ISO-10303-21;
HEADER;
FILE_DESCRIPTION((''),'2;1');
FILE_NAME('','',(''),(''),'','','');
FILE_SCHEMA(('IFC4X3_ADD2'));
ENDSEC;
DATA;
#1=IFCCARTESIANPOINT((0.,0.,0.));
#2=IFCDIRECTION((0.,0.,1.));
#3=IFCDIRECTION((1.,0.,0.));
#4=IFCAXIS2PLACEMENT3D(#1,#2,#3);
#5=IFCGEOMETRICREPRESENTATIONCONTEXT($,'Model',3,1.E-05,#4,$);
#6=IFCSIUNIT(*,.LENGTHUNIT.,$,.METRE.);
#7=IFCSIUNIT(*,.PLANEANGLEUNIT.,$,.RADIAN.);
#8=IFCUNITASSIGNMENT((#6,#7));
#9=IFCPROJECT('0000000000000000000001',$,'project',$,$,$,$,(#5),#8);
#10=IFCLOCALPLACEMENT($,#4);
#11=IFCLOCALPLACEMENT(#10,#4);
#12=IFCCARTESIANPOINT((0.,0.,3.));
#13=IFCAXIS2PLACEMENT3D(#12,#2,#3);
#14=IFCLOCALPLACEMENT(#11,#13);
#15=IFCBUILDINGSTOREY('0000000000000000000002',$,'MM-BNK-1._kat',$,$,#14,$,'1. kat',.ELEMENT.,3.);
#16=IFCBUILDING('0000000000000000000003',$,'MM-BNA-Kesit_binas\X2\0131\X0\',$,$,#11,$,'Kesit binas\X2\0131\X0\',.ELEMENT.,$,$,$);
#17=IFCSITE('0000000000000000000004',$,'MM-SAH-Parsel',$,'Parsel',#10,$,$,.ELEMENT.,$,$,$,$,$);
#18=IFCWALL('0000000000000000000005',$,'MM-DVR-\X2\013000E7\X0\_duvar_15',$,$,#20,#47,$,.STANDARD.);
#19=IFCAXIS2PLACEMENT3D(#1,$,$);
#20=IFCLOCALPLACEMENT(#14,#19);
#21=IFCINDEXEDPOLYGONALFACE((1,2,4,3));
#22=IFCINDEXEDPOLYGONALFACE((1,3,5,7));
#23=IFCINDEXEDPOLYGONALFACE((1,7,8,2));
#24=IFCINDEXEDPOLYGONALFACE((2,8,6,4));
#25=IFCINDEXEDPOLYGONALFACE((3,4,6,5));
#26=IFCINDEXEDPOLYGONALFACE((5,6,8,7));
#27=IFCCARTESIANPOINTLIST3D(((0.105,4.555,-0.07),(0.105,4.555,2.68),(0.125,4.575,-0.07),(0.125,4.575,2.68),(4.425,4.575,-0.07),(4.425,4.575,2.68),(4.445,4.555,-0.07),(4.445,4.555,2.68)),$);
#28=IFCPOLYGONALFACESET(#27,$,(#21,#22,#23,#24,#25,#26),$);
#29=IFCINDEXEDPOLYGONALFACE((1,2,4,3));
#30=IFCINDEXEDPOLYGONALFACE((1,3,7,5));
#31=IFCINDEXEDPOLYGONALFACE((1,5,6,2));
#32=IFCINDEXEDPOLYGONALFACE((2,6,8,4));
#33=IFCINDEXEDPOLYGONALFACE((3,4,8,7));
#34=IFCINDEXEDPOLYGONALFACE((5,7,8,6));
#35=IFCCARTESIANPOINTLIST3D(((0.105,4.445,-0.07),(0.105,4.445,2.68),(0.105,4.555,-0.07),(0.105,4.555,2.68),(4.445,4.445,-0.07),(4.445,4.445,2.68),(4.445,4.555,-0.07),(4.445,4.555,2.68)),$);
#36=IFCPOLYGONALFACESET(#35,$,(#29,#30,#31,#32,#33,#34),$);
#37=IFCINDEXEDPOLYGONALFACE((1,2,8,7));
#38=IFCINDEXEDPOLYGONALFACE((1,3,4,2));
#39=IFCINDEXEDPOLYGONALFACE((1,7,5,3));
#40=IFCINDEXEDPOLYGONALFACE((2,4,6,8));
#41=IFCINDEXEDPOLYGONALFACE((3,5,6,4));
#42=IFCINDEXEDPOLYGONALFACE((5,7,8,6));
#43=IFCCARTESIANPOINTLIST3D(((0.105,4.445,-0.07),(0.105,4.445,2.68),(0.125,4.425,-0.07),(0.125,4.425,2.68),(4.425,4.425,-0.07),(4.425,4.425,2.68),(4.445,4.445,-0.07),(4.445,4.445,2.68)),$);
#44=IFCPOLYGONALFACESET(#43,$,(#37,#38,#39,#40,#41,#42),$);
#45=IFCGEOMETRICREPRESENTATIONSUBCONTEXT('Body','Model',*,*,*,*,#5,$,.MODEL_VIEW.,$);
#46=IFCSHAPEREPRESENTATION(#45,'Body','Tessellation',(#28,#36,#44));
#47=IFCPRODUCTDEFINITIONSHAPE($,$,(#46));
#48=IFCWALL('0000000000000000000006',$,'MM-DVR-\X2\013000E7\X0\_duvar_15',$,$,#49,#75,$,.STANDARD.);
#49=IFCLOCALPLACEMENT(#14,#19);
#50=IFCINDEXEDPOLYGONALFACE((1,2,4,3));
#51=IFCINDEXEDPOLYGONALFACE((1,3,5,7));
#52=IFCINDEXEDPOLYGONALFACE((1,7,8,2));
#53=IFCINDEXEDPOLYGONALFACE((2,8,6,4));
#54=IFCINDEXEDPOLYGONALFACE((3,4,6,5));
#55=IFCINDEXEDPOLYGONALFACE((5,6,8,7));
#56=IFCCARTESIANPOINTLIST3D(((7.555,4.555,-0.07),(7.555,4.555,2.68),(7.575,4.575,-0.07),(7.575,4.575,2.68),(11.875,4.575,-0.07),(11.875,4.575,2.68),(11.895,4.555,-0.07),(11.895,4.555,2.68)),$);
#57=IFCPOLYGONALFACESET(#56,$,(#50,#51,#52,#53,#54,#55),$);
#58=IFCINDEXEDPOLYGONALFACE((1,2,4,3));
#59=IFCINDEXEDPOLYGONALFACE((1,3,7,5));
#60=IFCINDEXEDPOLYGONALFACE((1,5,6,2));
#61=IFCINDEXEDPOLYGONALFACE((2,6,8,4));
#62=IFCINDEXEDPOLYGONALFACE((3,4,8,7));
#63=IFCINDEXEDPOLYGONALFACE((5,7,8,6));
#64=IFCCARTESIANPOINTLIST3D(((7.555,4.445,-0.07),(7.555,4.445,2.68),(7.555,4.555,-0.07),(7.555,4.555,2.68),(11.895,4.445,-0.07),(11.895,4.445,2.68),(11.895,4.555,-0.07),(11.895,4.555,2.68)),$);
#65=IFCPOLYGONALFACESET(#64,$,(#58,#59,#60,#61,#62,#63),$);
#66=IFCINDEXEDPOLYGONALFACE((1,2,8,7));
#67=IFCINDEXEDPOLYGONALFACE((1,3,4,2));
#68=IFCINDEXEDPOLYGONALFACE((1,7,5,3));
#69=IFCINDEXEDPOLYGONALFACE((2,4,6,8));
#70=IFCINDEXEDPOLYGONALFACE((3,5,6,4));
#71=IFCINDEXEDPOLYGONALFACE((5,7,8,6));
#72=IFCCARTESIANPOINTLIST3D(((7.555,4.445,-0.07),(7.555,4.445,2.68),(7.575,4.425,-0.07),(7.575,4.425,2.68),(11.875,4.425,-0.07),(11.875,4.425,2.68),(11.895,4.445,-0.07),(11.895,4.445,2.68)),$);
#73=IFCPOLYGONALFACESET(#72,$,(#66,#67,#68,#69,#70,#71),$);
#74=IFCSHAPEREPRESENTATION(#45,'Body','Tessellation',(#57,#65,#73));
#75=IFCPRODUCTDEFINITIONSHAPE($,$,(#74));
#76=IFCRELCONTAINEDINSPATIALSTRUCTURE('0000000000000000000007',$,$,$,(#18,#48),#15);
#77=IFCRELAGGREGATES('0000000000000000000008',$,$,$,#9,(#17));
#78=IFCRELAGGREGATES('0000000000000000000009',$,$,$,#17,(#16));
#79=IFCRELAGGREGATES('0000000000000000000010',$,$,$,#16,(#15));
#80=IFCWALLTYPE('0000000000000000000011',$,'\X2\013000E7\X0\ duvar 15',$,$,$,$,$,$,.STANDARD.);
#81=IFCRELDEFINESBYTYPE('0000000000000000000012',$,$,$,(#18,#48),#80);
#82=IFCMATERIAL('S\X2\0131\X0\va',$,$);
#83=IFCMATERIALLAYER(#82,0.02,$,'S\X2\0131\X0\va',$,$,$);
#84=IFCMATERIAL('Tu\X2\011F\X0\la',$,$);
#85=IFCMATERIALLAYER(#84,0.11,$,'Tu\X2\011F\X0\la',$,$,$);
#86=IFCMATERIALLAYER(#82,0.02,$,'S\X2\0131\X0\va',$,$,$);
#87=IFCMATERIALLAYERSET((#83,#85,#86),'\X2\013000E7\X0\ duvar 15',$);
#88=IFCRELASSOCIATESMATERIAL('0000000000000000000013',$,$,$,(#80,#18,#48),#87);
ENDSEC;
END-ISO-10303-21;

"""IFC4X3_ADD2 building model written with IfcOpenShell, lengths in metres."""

from ifc_helpers import new_model, si_unit, frame, origin_with_axes, place, context, subcontext, project, spatial, polyline, outline, extrude, material, layer, layer_set, type_object, element, save


model = new_model("IFC4X3_ADD2")

# Units and contexts
model_context = context("Model", 3, precision=1e-05, world=origin_with_axes())
body_context = subcontext(model_context, "Body", "Model", "MODEL_VIEW")
ifc_project = project(units=[si_unit("LENGTHUNIT", "METRE"), si_unit("PLANEANGLEUNIT", "RADIAN")], contexts=[model_context])

# Site, building, storey
site_placement = place(None, origin_with_axes())
site = spatial("IfcSite", under=ifc_project, at=site_placement, Name="MM-SAH-Parsel", ObjectType="Parsel", CompositionType="ELEMENT")
building_placement = place(site_placement, origin_with_axes())
building = spatial("IfcBuilding", under=site, at=building_placement, Name="MM-BNA-Kesit_binası", LongName="Kesit binası", CompositionType="ELEMENT")
storey_placement = place(building_placement, frame((0.0, 0.0, 3.0), z_axis=(0.0, 0.0, 1.0), x_axis=(1.0, 0.0, 0.0)))
storey = spatial("IfcBuildingStorey", under=building, at=storey_placement, Name="MM-BNK-1._kat", LongName="1. kat", CompositionType="ELEMENT", Elevation=3.0)

# Shared definitions
ifc_material_1 = material(Name="Tuğla")

# Shared definitions
ifc_material_2 = material(Name="Sıva")
ifc_layer_1 = layer(ifc_material_2, 0.02, Name="Sıva")
ifc_layer_2 = layer(ifc_material_1, 0.11, Name="Tuğla")
ifc_layer_3 = layer(ifc_material_2, 0.02, Name="Sıva")
ifc_layer_set_1 = layer_set([ifc_layer_1, ifc_layer_2, ifc_layer_3], Name="İç duvar 15")
wall_type_1 = type_object("IfcWallType", Name="İç duvar 15", PredefinedType="STANDARD", material=ifc_layer_set_1)

# Walls
wall_1_placement = place(storey_placement, origin_with_axes())
element("IfcWall", 1, at=wall_1_placement, inside=storey, type_object=wall_type_1, material=ifc_layer_set_1, Name="MM-DVR-İç_duvar_15", PredefinedType="STANDARD", context=body_context, shape_type="SweptSolid", body=[
    extrude(outline(polyline([(0.125, 4.575), (4.425, 4.575), (4.445, 4.555), (0.105, 4.555), (0.125, 4.575)])), frame((0.0, 0.0, -0.07)), (0.0, 0.0, 1.0), 2.75),
    extrude(outline(polyline([(0.105, 4.555), (4.445, 4.555), (4.445, 4.445), (0.105, 4.445), (0.105, 4.555)])), frame((0.0, 0.0, -0.07)), (0.0, 0.0, 1.0), 2.75),
    extrude(outline(polyline([(0.105, 4.445), (4.445, 4.445), (4.425, 4.425), (0.125, 4.425), (0.105, 4.445)])), frame((0.0, 0.0, -0.07)), (0.0, 0.0, 1.0), 2.75),
])
wall_2_placement = place(storey_placement, origin_with_axes())
element("IfcWall", 2, at=wall_2_placement, inside=storey, type_object=wall_type_1, material=ifc_layer_set_1, Name="MM-DVR-İç_duvar_15", PredefinedType="STANDARD", context=body_context, shape_type="SweptSolid", body=[
    extrude(outline(polyline([(7.575, 4.575), (11.875, 4.575), (11.895, 4.555), (7.555, 4.555), (7.575, 4.575)])), frame((0.0, 0.0, -0.07)), (0.0, 0.0, 1.0), 2.75),
    extrude(outline(polyline([(7.555, 4.555), (11.895, 4.555), (11.895, 4.445), (7.555, 4.445), (7.555, 4.555)])), frame((0.0, 0.0, -0.07)), (0.0, 0.0, 1.0), 2.75),
    extrude(outline(polyline([(7.555, 4.445), (11.895, 4.445), (11.875, 4.425), (7.575, 4.425), (7.555, 4.445)])), frame((0.0, 0.0, -0.07)), (0.0, 0.0, 1.0), 2.75),
])

save(model, "model.ifc")
